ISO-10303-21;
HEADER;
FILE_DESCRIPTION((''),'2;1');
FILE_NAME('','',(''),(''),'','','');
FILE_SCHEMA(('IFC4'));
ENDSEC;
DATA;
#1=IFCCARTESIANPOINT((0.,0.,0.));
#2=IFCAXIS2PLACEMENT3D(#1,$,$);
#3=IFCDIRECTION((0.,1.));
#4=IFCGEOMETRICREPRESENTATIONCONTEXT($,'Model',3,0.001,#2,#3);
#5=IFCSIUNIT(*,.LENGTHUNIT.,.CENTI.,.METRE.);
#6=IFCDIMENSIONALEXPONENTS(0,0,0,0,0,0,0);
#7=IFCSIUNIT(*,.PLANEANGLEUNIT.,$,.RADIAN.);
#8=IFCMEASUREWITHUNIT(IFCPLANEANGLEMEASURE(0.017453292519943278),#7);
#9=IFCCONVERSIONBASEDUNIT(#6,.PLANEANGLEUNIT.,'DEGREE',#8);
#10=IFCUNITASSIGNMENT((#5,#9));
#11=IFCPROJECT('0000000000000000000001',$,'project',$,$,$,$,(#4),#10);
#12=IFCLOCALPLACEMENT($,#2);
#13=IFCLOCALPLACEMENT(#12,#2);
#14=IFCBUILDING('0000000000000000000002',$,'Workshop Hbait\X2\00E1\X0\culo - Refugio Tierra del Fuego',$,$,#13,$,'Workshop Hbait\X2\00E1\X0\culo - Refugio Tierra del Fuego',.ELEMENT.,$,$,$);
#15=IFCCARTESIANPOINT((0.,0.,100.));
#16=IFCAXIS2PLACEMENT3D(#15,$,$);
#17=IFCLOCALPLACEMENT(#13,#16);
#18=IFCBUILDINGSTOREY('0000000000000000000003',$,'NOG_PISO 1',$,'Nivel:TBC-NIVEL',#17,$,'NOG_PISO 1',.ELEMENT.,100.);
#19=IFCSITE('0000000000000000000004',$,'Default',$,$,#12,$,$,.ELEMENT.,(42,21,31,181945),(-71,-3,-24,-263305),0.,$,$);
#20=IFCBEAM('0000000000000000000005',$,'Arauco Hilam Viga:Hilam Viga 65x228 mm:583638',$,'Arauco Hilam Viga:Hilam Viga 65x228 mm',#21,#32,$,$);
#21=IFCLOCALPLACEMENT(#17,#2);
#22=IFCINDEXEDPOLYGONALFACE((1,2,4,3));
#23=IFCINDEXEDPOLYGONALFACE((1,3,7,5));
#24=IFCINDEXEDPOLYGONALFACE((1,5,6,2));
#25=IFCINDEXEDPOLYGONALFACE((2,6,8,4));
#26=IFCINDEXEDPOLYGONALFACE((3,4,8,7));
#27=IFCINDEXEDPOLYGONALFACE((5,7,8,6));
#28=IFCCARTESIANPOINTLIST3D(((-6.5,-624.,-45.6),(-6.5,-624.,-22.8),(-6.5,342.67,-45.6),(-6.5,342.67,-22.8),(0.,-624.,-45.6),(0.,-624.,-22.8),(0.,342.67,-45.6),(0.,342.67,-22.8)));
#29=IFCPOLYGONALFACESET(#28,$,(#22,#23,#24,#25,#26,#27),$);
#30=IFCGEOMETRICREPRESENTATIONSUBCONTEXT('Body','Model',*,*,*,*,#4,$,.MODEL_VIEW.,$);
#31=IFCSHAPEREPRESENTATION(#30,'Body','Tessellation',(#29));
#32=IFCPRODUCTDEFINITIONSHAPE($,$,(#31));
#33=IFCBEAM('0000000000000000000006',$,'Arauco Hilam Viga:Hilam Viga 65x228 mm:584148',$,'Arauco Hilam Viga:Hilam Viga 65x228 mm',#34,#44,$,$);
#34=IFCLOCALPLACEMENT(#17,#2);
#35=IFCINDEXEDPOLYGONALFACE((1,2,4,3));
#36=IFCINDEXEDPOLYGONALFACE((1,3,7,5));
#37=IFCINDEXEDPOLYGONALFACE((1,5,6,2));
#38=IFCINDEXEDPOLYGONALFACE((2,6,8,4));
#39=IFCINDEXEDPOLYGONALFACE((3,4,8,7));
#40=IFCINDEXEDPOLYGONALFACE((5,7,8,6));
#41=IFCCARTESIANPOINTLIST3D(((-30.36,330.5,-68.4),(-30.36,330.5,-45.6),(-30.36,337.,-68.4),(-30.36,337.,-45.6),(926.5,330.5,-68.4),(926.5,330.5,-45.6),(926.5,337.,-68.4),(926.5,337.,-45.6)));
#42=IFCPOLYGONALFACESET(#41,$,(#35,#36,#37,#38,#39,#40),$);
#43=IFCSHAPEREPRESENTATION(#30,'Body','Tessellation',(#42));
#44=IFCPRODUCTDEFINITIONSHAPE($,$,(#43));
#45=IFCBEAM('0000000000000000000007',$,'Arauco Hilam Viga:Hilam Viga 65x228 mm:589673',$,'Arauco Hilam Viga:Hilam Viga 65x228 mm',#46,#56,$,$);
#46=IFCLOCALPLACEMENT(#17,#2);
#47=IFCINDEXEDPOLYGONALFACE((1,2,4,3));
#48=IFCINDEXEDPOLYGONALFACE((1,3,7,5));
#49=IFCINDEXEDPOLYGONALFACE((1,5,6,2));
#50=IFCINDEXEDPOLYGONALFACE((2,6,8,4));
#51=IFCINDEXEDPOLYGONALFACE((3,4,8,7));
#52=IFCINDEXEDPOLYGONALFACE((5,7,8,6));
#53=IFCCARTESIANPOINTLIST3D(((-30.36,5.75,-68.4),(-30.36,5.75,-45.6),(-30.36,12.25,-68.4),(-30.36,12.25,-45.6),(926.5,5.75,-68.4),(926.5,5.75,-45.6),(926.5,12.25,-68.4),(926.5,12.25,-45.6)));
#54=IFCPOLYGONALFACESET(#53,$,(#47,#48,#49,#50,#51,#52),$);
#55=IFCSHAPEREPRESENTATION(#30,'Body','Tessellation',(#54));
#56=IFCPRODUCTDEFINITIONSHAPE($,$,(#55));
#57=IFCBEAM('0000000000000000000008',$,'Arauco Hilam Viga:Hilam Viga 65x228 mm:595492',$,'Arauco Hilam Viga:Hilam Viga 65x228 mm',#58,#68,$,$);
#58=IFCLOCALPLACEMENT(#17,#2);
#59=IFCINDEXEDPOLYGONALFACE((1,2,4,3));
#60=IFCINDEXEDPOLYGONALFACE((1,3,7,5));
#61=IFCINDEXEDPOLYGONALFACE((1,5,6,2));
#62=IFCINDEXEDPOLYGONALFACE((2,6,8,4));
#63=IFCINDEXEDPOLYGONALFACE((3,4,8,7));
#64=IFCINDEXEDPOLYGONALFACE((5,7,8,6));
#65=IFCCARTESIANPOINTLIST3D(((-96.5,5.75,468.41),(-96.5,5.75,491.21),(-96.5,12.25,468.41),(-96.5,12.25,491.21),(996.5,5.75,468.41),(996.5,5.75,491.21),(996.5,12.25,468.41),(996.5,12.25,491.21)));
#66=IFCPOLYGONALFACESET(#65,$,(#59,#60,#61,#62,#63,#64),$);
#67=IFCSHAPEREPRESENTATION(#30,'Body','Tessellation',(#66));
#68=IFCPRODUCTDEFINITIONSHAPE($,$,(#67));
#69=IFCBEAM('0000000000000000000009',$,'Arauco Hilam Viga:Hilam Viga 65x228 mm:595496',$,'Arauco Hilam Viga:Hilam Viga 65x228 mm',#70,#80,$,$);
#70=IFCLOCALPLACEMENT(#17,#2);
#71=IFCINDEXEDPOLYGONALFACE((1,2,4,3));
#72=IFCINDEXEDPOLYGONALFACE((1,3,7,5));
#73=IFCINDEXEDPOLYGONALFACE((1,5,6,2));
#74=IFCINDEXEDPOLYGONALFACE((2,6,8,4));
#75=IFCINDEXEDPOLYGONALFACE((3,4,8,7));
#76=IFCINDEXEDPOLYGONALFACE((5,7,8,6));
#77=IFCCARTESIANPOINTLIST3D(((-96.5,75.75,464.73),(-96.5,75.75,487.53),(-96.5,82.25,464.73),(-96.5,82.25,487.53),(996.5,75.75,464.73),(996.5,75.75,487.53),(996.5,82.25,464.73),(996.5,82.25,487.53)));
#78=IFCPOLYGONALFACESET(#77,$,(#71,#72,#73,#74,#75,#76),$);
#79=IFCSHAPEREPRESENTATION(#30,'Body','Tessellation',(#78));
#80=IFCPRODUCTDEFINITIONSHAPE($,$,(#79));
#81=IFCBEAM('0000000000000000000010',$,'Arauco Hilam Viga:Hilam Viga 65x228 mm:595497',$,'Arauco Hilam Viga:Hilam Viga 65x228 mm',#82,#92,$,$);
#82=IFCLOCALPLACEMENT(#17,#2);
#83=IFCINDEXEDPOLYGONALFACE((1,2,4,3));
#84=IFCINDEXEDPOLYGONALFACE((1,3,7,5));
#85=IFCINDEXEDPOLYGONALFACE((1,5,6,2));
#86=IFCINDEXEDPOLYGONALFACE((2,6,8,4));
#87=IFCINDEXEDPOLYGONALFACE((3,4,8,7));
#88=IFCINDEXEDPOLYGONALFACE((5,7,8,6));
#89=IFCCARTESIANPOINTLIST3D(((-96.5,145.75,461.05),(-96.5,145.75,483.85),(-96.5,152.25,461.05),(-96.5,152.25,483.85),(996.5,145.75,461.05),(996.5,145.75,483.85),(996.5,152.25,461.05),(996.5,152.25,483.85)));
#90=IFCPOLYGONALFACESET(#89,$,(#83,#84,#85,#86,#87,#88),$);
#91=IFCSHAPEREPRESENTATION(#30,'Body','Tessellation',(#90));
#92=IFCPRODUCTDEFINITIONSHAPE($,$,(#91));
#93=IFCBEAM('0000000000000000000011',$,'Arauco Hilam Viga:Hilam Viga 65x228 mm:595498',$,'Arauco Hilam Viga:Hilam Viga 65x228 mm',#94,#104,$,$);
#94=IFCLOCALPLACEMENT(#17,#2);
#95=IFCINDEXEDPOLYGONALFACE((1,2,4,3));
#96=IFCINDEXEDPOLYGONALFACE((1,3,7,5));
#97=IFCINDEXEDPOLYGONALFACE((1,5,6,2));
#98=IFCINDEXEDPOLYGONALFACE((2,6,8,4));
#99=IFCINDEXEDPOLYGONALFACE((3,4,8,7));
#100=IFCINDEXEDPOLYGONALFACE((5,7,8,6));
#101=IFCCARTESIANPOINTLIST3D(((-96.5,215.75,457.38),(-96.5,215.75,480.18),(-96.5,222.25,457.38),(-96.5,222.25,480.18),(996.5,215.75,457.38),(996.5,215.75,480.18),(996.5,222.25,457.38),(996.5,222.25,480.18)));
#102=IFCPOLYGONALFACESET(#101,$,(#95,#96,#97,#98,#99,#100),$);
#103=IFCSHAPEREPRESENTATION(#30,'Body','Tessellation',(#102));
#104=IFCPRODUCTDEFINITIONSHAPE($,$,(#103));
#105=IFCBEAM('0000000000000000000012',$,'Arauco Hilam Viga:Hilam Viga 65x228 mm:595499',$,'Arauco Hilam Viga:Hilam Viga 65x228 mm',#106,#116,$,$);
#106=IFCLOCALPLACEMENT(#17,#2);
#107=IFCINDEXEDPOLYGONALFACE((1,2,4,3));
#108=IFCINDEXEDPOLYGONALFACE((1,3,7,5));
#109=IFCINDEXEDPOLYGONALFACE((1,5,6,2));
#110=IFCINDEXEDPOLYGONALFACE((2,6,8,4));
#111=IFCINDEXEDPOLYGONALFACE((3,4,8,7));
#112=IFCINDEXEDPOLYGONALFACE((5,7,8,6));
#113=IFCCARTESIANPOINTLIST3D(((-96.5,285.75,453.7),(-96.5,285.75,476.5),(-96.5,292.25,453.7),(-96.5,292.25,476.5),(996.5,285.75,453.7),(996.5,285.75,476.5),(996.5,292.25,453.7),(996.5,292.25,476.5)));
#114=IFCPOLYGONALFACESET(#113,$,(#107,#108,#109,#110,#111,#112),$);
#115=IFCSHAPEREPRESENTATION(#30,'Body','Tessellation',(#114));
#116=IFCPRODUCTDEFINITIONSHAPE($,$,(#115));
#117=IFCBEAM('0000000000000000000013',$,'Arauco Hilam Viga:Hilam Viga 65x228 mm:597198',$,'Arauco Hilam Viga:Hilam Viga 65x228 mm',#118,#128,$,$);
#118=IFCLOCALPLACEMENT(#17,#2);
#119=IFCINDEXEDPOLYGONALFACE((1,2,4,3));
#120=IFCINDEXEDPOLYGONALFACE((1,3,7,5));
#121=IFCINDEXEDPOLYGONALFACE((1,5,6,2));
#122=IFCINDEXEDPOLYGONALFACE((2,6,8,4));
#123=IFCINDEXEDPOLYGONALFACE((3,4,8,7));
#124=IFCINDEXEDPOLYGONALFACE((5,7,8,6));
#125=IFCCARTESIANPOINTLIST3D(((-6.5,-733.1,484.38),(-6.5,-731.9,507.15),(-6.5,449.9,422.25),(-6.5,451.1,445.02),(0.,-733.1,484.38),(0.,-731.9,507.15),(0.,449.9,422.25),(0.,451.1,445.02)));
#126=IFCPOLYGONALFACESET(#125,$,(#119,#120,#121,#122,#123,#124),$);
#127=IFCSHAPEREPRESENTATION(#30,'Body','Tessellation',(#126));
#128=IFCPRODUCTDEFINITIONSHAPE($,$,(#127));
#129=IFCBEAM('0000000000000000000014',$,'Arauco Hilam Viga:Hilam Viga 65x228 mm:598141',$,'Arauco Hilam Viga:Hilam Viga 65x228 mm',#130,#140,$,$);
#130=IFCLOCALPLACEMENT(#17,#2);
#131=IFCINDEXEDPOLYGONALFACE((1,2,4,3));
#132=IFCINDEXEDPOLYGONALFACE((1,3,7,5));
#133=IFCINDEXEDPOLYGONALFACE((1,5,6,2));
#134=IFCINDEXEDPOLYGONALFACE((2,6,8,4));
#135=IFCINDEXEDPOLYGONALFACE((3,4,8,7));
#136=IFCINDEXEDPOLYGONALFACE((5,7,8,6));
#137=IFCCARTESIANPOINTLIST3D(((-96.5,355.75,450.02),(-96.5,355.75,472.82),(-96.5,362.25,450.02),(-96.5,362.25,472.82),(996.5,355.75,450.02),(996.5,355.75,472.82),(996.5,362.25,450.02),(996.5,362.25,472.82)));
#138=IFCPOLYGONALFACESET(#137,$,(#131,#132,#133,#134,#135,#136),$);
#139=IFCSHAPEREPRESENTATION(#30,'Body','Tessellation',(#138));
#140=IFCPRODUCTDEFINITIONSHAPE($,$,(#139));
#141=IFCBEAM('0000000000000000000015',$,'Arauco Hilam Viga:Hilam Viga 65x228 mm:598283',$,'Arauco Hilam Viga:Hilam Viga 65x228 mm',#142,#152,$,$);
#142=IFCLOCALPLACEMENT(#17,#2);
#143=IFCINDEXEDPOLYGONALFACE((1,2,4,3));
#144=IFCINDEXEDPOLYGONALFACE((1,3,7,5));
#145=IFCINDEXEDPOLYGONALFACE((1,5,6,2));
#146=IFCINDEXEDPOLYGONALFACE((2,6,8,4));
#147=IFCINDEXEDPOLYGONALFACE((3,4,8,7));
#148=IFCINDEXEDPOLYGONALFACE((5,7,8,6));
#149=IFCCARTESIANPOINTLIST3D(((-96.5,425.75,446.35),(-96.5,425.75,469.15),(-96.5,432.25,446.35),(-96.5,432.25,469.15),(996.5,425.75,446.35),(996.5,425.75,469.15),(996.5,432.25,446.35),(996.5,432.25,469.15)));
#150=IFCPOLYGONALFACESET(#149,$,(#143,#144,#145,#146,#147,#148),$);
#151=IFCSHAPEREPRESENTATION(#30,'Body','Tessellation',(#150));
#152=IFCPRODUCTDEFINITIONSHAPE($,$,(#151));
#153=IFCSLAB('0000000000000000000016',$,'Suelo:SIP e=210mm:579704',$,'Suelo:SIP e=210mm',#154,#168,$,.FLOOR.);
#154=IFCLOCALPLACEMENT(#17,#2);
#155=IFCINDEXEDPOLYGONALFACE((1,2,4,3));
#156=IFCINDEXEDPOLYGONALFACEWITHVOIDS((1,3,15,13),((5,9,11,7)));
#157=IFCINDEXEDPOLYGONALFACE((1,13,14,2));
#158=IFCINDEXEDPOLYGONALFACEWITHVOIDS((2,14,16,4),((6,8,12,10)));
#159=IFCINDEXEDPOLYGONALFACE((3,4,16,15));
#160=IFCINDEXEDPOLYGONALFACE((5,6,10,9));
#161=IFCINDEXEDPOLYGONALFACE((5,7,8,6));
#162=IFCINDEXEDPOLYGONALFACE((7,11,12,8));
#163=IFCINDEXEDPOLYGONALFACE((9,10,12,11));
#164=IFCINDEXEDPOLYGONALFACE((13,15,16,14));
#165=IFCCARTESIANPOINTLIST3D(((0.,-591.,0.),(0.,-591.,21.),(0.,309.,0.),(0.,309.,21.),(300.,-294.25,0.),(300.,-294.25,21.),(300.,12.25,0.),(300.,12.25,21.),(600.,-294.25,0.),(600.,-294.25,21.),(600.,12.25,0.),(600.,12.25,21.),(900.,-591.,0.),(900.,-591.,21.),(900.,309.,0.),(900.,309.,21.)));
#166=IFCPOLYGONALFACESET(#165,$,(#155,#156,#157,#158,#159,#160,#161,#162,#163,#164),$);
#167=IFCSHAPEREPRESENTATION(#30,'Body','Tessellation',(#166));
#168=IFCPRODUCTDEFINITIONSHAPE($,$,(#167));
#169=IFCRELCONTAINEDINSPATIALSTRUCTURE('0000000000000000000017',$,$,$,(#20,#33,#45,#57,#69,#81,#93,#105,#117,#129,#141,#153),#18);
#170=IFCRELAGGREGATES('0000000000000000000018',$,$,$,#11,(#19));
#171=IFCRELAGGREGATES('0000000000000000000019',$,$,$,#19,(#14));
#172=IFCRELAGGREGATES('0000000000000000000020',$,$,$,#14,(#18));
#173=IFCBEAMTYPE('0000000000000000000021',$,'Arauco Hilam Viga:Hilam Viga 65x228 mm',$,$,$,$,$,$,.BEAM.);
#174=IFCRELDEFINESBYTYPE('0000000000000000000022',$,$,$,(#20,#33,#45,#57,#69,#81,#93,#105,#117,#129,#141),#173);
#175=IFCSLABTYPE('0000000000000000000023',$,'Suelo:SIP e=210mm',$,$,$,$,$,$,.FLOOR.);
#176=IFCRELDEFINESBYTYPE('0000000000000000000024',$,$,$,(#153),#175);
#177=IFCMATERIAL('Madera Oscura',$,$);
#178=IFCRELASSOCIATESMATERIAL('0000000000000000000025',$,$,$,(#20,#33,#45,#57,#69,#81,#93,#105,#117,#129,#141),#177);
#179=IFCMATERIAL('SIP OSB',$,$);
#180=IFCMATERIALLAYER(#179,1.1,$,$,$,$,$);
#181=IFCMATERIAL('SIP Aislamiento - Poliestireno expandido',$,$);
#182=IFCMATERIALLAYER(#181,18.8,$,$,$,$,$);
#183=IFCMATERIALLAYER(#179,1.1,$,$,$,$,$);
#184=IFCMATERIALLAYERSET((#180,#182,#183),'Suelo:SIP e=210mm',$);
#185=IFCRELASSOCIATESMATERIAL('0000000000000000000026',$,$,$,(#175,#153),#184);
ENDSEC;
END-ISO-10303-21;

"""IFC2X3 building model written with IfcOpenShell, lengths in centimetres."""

from ifc_helpers import new_model, entity, si_unit, converted_unit, direction, frame, frame_2d, origin, origin_2d_with_axis, place, context, subcontext, project, spatial, rectangle, extrude, boolean, material, layer, layer_set, layer_usage, type_object, element, save


model = new_model("IFC2X3")

# Units and contexts
model_context = context("Model", 3, precision=0.001, world=origin(), true_north=direction((0.0, 1.0)))
body_context = subcontext(model_context, "Body", "Model", "MODEL_VIEW")
ifc_project = project(units=[si_unit("LENGTHUNIT", "METRE", prefix="CENTI"), converted_unit("PLANEANGLEUNIT", "DEGREE", entity("IfcPlaneAngleMeasure", 0.017453292519943278), si_unit("PLANEANGLEUNIT", "RADIAN"), dimensions=[0, 0, 0, 0, 0, 0, 0])], contexts=[model_context])

# Site, building, storey
site_placement = place(None, origin())
site = spatial("IfcSite", under=ifc_project, at=site_placement, Name="Default", CompositionType="ELEMENT", RefLatitude=(42, 21, 31, 181945), RefLongitude=(-71, -3, -24, -263305), RefElevation=0.0)
building_placement = place(site_placement, origin())
building = spatial("IfcBuilding", under=site, at=building_placement, Name="Workshop Hbaitáculo - Refugio Tierra del Fuego", LongName="Workshop Hbaitáculo - Refugio Tierra del Fuego", CompositionType="ELEMENT")
storey_placement = place(building_placement, frame((0.0, 0.0, 100.0)))
storey = spatial("IfcBuildingStorey", under=building, at=storey_placement, Name="NOG_PISO 1", ObjectType="Nivel:TBC-NIVEL", LongName="NOG_PISO 1", CompositionType="ELEMENT", Elevation=100.0)

# Beams
ifc_material_1 = material(Name="Madera Oscura")
beam_type = type_object("IfcBeamType", Name="Arauco Hilam Viga:Hilam Viga 65x228 mm", PredefinedType="BEAM")
beam_1_placement = place(storey_placement, frame((-3.25, 318.11, -22.8), z_axis=(0.0, 0.0, 1.0), x_axis=(0.0, -1.0, 0.0)))
element("IfcBeam", 1, at=beam_1_placement, inside=storey, type_object=beam_type, material=ifc_material_1, Name="Arauco Hilam Viga:Hilam Viga 65x228 mm:583638", ObjectType="Arauco Hilam Viga:Hilam Viga 65x228 mm", context=body_context, shape_type="SweptSolid", body=[
    extrude(rectangle(XDim=22.8, YDim=6.5, at=frame_2d((0.0, 0.0), x_axis=(1.0, 0.0))), frame((-24.56, 0.0, -11.4), z_axis=(1.0, 0.0, 0.0), x_axis=(0.0, 0.0, -1.0)), (0.0, 0.0, 1.0), 966.67),
])
beam_2_placement = place(storey_placement, frame((-96.14, 333.75, -45.6)))
element("IfcBeam", 2, at=beam_2_placement, inside=storey, type_object=beam_type, material=ifc_material_1, Name="Arauco Hilam Viga:Hilam Viga 65x228 mm:584148", ObjectType="Arauco Hilam Viga:Hilam Viga 65x228 mm", context=body_context, shape_type="SweptSolid", body=[
    extrude(rectangle(XDim=22.8, YDim=6.5, at=frame_2d((0.0, 0.0), x_axis=(1.0, 0.0))), frame((65.78, 0.0, -11.4), z_axis=(1.0, 0.0, 0.0), x_axis=(0.0, 0.0, -1.0)), (0.0, 0.0, 1.0), 956.86),
])
beam_3_placement = place(storey_placement, frame((-96.14, 9.0, -45.6)))
element("IfcBeam", 3, at=beam_3_placement, inside=storey, type_object=beam_type, material=ifc_material_1, Name="Arauco Hilam Viga:Hilam Viga 65x228 mm:589673", ObjectType="Arauco Hilam Viga:Hilam Viga 65x228 mm", context=body_context, shape_type="SweptSolid", body=[
    extrude(rectangle(XDim=22.8, YDim=6.5, at=frame_2d((0.0, 0.0), x_axis=(1.0, 0.0))), frame((65.78, 0.0, -11.4), z_axis=(1.0, 0.0, 0.0), x_axis=(0.0, 0.0, -1.0)), (0.0, 0.0, 1.0), 956.86),
])
beam_4_placement = place(storey_placement, frame((-127.75, 9.0, 491.21)))
element("IfcBeam", 4, at=beam_4_placement, inside=storey, type_object=beam_type, material=ifc_material_1, Name="Arauco Hilam Viga:Hilam Viga 65x228 mm:595492", ObjectType="Arauco Hilam Viga:Hilam Viga 65x228 mm", context=body_context, shape_type="SweptSolid", body=[
    extrude(rectangle(XDim=22.8, YDim=6.5, at=frame_2d((0.0, 0.0), x_axis=(1.0, 0.0))), frame((31.25, 0.0, -11.4), z_axis=(1.0, 0.0, 0.0), x_axis=(0.0, 0.0, -1.0)), (0.0, 0.0, 1.0), 1093.0),
])
beam_5_placement = place(storey_placement, frame((-127.75, 79.0, 487.53)))
element("IfcBeam", 5, at=beam_5_placement, inside=storey, type_object=beam_type, material=ifc_material_1, Name="Arauco Hilam Viga:Hilam Viga 65x228 mm:595496", ObjectType="Arauco Hilam Viga:Hilam Viga 65x228 mm", context=body_context, shape_type="SweptSolid", body=[
    extrude(rectangle(XDim=22.8, YDim=6.5, at=frame_2d((0.0, 0.0), x_axis=(1.0, 0.0))), frame((31.25, 0.0, -11.4), z_axis=(1.0, 0.0, 0.0), x_axis=(0.0, 0.0, -1.0)), (0.0, 0.0, 1.0), 1093.0),
])
beam_6_placement = place(storey_placement, frame((-127.75, 149.0, 483.85)))
element("IfcBeam", 6, at=beam_6_placement, inside=storey, type_object=beam_type, material=ifc_material_1, Name="Arauco Hilam Viga:Hilam Viga 65x228 mm:595497", ObjectType="Arauco Hilam Viga:Hilam Viga 65x228 mm", context=body_context, shape_type="SweptSolid", body=[
    extrude(rectangle(XDim=22.8, YDim=6.5, at=frame_2d((0.0, 0.0), x_axis=(1.0, 0.0))), frame((31.25, 0.0, -11.4), z_axis=(1.0, 0.0, 0.0), x_axis=(0.0, 0.0, -1.0)), (0.0, 0.0, 1.0), 1093.0),
])
beam_7_placement = place(storey_placement, frame((-127.75, 219.0, 480.18)))
element("IfcBeam", 7, at=beam_7_placement, inside=storey, type_object=beam_type, material=ifc_material_1, Name="Arauco Hilam Viga:Hilam Viga 65x228 mm:595498", ObjectType="Arauco Hilam Viga:Hilam Viga 65x228 mm", context=body_context, shape_type="SweptSolid", body=[
    extrude(rectangle(XDim=22.8, YDim=6.5, at=frame_2d((0.0, 0.0), x_axis=(1.0, 0.0))), frame((31.25, 0.0, -11.4), z_axis=(1.0, 0.0, 0.0), x_axis=(0.0, 0.0, -1.0)), (0.0, 0.0, 1.0), 1093.0),
])
beam_8_placement = place(storey_placement, frame((-127.75, 289.0, 476.5)))
element("IfcBeam", 8, at=beam_8_placement, inside=storey, type_object=beam_type, material=ifc_material_1, Name="Arauco Hilam Viga:Hilam Viga 65x228 mm:595499", ObjectType="Arauco Hilam Viga:Hilam Viga 65x228 mm", context=body_context, shape_type="SweptSolid", body=[
    extrude(rectangle(XDim=22.8, YDim=6.5, at=frame_2d((0.0, 0.0), x_axis=(1.0, 0.0))), frame((31.25, 0.0, -11.4), z_axis=(1.0, 0.0, 0.0), x_axis=(0.0, 0.0, -1.0)), (0.0, 0.0, 1.0), 1093.0),
])
beam_9_placement = place(storey_placement, frame((-3.25, 318.11, 452.0), z_axis=(0.0, 0.052449, 0.998624), x_axis=(0.0, -0.998624, 0.052449)))
element("IfcBeam", 9, at=beam_9_placement, inside=storey, type_object=beam_type, material=ifc_material_1, Name="Arauco Hilam Viga:Hilam Viga 65x228 mm:597198", ObjectType="Arauco Hilam Viga:Hilam Viga 65x228 mm", context=body_context, shape_type="SweptSolid", body=[
    extrude(rectangle(XDim=22.8, YDim=6.5, at=origin_2d_with_axis()), frame((-133.18, 0.0, -11.4), z_axis=(1.0, 0.0, 0.0), x_axis=(0.0, 0.0, -1.0)), (0.0, 0.0, 1.0), 1184.63),
])
beam_10_placement = place(storey_placement, frame((-127.75, 359.0, 472.82)))
element("IfcBeam", 10, at=beam_10_placement, inside=storey, type_object=beam_type, material=ifc_material_1, Name="Arauco Hilam Viga:Hilam Viga 65x228 mm:598141", ObjectType="Arauco Hilam Viga:Hilam Viga 65x228 mm", context=body_context, shape_type="SweptSolid", body=[
    extrude(rectangle(XDim=22.8, YDim=6.5, at=frame_2d((0.0, 0.0), x_axis=(1.0, 0.0))), frame((31.25, 0.0, -11.4), z_axis=(1.0, 0.0, 0.0), x_axis=(0.0, 0.0, -1.0)), (0.0, 0.0, 1.0), 1093.0),
])
beam_11_placement = place(storey_placement, frame((-127.75, 429.0, 469.15)))
element("IfcBeam", 11, at=beam_11_placement, inside=storey, type_object=beam_type, material=ifc_material_1, Name="Arauco Hilam Viga:Hilam Viga 65x228 mm:598283", ObjectType="Arauco Hilam Viga:Hilam Viga 65x228 mm", context=body_context, shape_type="SweptSolid", body=[
    extrude(rectangle(XDim=22.8, YDim=6.5, at=frame_2d((0.0, 0.0), x_axis=(1.0, 0.0))), frame((31.25, 0.0, -11.4), z_axis=(1.0, 0.0, 0.0), x_axis=(0.0, 0.0, -1.0)), (0.0, 0.0, 1.0), 1093.0),
])

# Slab, opening
ifc_material_2 = material(Name="SIP OSB")
ifc_layer_1 = layer(ifc_material_2, 1.1)
ifc_material_3 = material(Name="SIP Aislamiento - Poliestireno expandido")
ifc_layer_2 = layer(ifc_material_3, 18.8)
ifc_layer_3 = layer(ifc_material_2, 1.1)
ifc_layer_set_1 = layer_set([ifc_layer_1, ifc_layer_2, ifc_layer_3], Name="Suelo:SIP e=210mm")
ifc_layer_usage_1 = layer_usage(ifc_layer_set_1, "AXIS3", "POSITIVE", 0.0)
slab_type_1 = type_object("IfcSlabType", Name="Suelo:SIP e=210mm", PredefinedType="FLOOR", material=ifc_layer_set_1)
slab_1_placement = place(storey_placement, origin())
slab_1 = element("IfcSlab", 12, at=slab_1_placement, inside=storey, type_object=slab_type_1, material=ifc_layer_usage_1, Name="Suelo:SIP e=210mm:579704", ObjectType="Suelo:SIP e=210mm", PredefinedType="FLOOR", context=body_context, shape_type="CSG", body=[
    boolean("DIFFERENCE", extrude(rectangle(XDim=900.0, YDim=900.0, at=origin_2d_with_axis()), frame((450.0, -141.0, 21.0), z_axis=(0.0, 0.0, -1.0), x_axis=(0.0, 1.0, 0.0)), (0.0, 0.0, 1.0), 21.0), extrude(rectangle(XDim=306.5, YDim=300.0, at=frame_2d((0.0, 0.0), x_axis=(1.0, 0.0))), frame((450.0, -141.0, 0.0), z_axis=(0.0, 0.0, 1.0), x_axis=(0.0, 1.0, 0.0)), (0.0, 0.0, 1.0), 21.0)),
])
opening_1_placement = place(slab_1_placement, origin())
element("IfcOpeningElement", 13, at=opening_1_placement, cuts=slab_1, ObjectType="Opening", context=body_context, shape_type="SweptSolid", body=[
    extrude(rectangle(XDim=306.5, YDim=300.0, at=frame_2d((450.0, -141.0), x_axis=(0.0, -1.0))), frame((0.0, 0.0, 21.0)), (0.0, 0.0, -1.0), 21.0),
])

save(model, "model.ifc")
